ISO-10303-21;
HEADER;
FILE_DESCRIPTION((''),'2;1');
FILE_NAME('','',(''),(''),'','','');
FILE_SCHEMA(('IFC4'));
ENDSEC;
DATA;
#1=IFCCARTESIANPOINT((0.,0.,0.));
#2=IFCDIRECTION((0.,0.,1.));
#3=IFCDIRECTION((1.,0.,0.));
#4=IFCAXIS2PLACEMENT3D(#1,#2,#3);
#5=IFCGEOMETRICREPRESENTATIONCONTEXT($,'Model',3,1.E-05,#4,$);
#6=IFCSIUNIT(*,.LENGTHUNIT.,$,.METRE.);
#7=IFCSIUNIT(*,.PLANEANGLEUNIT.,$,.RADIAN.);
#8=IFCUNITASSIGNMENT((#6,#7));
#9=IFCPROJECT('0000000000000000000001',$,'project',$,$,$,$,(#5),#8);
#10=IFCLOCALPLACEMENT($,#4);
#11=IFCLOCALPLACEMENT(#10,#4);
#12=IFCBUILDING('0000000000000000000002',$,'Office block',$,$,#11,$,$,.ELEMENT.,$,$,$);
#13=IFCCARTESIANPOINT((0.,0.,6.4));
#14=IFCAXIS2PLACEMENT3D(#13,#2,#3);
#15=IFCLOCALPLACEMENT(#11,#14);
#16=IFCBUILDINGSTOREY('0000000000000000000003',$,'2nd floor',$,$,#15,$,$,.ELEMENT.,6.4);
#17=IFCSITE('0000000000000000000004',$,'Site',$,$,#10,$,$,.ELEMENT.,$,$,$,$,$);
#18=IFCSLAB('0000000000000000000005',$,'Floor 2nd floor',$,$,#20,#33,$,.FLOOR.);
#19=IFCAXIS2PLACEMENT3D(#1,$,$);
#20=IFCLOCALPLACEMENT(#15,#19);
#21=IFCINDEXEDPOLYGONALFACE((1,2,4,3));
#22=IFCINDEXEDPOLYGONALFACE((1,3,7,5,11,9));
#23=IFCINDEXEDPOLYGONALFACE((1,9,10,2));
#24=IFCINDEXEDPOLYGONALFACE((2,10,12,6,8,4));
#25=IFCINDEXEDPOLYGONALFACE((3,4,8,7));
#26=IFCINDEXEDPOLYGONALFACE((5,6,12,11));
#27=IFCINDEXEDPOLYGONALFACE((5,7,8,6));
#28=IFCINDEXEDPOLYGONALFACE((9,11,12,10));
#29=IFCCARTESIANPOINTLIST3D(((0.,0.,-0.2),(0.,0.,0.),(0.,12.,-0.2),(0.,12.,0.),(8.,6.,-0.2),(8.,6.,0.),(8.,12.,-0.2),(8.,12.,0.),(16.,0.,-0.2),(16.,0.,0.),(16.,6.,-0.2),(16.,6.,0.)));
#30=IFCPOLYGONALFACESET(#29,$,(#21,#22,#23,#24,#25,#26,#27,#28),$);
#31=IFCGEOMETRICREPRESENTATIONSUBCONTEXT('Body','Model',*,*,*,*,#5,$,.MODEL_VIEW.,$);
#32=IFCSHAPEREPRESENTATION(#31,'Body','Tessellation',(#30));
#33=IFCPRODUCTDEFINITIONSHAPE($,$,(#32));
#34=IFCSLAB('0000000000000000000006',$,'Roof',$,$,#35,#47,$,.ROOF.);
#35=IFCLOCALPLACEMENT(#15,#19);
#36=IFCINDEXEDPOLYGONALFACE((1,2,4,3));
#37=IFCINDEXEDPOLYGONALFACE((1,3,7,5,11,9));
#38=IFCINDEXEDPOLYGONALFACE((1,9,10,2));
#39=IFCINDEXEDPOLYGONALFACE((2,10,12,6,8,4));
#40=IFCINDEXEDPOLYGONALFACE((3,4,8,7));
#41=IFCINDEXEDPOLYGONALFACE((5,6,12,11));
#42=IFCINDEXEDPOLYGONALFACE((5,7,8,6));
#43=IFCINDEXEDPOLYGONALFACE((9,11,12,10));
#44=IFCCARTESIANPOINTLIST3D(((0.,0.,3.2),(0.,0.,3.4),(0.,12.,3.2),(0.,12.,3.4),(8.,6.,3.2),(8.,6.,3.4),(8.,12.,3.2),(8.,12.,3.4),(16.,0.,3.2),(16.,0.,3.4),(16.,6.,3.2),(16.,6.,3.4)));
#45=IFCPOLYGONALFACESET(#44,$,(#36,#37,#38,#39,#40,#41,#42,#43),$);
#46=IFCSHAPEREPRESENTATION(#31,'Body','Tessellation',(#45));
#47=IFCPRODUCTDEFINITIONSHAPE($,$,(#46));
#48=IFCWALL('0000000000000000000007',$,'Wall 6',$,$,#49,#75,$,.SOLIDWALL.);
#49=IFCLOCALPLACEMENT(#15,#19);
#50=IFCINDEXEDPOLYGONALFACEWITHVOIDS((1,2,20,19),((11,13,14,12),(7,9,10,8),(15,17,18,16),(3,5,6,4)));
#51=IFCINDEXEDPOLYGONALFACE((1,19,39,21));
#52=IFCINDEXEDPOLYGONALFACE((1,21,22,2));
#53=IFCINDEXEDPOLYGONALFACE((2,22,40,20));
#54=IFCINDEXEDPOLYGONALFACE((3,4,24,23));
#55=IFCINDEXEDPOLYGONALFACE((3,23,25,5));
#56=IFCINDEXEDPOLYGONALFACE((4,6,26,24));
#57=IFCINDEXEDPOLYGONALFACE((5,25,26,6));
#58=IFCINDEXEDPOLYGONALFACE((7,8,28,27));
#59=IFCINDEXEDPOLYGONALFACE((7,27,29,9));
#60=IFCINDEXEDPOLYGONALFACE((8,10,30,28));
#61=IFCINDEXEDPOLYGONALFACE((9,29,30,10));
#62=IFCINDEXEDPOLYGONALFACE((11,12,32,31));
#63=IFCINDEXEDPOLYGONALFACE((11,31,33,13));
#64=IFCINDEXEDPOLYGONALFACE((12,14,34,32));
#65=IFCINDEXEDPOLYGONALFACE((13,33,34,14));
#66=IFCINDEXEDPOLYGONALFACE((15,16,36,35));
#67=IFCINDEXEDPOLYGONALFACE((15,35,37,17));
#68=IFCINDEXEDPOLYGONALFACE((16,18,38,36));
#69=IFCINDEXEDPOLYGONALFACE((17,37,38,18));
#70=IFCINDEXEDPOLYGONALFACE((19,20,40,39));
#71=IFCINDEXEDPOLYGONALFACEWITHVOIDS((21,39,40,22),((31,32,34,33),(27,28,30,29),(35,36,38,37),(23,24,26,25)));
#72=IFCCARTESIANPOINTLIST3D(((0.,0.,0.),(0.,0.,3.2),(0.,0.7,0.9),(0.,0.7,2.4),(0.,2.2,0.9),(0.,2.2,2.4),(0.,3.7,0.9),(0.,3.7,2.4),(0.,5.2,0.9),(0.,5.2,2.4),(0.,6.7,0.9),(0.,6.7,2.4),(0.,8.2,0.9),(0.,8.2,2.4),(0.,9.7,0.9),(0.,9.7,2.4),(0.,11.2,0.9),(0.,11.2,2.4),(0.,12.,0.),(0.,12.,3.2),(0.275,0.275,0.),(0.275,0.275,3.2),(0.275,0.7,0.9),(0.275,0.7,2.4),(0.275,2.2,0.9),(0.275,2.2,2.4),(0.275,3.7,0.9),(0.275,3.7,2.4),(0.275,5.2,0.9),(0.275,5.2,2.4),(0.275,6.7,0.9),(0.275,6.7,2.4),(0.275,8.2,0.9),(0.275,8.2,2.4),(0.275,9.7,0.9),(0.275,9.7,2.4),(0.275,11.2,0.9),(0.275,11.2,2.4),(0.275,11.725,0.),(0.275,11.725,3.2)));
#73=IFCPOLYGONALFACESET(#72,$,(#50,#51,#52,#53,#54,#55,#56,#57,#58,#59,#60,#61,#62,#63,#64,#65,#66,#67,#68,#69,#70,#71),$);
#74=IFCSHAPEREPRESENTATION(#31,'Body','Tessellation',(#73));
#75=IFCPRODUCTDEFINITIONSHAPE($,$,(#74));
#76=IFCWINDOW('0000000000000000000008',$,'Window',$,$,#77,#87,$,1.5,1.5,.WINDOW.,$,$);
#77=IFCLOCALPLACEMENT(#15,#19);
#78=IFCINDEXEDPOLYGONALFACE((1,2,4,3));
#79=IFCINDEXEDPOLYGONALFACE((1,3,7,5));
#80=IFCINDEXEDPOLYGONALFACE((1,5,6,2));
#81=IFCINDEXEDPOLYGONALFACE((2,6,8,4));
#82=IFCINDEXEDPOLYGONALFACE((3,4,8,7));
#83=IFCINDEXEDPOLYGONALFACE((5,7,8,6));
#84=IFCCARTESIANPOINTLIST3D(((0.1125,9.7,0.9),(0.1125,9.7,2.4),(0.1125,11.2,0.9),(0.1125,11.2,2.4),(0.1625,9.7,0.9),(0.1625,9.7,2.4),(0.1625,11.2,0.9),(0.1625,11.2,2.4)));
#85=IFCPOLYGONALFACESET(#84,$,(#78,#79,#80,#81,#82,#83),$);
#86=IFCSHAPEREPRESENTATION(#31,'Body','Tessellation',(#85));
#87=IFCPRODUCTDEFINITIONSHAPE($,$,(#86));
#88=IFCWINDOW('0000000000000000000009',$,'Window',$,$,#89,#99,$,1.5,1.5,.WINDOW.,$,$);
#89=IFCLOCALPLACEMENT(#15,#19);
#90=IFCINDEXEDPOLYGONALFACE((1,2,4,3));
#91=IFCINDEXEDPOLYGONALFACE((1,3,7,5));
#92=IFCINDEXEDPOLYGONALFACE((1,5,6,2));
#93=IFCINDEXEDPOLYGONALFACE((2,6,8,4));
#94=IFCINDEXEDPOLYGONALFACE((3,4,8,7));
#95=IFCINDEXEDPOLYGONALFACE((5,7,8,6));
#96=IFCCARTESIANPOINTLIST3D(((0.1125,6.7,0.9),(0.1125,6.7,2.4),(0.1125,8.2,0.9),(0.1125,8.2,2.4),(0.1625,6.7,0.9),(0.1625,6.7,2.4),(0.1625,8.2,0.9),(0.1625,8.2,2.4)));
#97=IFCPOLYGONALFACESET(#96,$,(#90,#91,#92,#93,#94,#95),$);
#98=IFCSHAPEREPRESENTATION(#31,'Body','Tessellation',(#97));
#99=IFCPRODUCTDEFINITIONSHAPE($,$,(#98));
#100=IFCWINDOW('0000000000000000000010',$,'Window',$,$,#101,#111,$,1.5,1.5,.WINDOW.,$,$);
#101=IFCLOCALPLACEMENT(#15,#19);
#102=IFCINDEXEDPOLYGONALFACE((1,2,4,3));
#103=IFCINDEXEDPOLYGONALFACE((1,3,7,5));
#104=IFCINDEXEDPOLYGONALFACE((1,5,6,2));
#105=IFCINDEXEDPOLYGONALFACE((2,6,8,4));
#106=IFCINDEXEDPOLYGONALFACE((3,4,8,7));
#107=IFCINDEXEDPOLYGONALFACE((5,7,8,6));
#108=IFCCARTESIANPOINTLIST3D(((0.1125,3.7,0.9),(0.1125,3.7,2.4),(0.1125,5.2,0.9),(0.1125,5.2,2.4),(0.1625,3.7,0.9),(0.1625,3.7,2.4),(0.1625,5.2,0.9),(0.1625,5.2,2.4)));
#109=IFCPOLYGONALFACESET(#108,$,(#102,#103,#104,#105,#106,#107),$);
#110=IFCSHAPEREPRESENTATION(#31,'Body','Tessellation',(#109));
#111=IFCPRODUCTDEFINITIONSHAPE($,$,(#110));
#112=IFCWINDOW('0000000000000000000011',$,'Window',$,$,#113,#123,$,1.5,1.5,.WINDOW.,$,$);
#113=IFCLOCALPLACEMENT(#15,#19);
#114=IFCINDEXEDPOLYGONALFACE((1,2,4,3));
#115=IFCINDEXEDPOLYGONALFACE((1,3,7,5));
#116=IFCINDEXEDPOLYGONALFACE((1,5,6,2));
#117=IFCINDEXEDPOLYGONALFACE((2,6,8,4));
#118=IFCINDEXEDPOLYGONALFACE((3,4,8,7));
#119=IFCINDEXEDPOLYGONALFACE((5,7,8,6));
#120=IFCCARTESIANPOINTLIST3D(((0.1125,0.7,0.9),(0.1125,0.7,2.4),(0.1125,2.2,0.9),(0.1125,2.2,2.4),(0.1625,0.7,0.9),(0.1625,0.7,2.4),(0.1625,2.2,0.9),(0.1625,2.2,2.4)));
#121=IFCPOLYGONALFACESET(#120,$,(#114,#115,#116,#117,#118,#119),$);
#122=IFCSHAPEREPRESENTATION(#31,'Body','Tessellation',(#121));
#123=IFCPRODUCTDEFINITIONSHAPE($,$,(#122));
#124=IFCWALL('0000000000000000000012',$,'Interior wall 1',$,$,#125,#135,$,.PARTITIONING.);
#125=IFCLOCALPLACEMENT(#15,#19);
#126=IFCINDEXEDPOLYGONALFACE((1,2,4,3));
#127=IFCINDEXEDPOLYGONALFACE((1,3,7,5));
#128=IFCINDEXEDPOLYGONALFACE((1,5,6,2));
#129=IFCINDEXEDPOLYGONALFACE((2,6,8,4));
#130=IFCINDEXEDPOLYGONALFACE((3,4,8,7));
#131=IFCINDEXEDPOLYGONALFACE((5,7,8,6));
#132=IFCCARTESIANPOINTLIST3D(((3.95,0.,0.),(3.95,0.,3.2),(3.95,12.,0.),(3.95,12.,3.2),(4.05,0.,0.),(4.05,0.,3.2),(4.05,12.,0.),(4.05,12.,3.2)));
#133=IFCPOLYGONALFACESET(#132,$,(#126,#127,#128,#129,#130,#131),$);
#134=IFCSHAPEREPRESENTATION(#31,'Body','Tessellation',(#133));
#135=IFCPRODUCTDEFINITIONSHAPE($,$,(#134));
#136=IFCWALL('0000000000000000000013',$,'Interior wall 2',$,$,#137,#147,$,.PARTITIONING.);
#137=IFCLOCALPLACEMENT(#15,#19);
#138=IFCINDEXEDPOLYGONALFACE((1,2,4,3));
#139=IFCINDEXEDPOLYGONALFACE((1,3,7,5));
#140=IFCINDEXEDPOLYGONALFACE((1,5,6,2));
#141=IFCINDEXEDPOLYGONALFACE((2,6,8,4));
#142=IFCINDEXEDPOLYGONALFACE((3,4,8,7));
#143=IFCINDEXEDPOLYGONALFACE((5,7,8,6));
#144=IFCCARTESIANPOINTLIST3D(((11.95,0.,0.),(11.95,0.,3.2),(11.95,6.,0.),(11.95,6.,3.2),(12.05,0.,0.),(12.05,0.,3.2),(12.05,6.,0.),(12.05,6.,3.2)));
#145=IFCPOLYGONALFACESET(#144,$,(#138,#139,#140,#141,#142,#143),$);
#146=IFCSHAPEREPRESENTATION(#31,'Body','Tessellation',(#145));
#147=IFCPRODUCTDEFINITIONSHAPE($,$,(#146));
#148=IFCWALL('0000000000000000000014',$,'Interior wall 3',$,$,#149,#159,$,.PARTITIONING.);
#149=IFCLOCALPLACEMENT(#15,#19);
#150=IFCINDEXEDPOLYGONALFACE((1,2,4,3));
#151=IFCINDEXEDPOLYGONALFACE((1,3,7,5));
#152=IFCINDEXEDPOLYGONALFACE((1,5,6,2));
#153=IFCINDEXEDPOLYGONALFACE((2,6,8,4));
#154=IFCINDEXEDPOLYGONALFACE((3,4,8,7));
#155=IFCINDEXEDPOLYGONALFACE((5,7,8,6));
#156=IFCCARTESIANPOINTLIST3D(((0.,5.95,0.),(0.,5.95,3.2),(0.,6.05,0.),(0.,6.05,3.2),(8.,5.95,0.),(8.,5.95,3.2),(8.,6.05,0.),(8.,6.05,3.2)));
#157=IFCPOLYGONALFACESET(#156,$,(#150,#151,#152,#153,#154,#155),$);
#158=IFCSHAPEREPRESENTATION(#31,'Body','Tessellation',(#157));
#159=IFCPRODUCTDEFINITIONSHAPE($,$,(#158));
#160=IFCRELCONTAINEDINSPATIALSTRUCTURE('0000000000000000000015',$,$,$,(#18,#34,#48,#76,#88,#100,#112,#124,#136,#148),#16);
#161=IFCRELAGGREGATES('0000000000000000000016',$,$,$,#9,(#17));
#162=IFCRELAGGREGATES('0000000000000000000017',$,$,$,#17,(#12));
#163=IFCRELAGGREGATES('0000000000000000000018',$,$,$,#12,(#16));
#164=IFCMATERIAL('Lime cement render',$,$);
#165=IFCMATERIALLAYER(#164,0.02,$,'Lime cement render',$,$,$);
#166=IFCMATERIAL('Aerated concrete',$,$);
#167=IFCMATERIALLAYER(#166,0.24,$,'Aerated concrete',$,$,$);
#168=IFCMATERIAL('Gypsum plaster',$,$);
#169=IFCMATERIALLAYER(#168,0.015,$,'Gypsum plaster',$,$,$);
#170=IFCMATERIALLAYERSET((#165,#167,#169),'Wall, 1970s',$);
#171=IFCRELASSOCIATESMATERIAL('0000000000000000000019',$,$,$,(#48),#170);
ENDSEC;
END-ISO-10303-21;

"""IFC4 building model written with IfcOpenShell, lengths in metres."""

from ifc_helpers import new_model, si_unit, frame, origin_with_axes, place, context, subcontext, project, spatial, polyline, outline, extrude, material, layer, layer_set, layer_usage, element, fill, save


model = new_model("IFC4")

# Units and contexts
model_context = context("Model", 3, precision=1e-05, world=origin_with_axes())
body_context = subcontext(model_context, "Body", "Model", "MODEL_VIEW")
ifc_project = project(units=[si_unit("LENGTHUNIT", "METRE"), si_unit("PLANEANGLEUNIT", "RADIAN")], contexts=[model_context])

# Site, building, storey
site_placement = place(None, origin_with_axes())
site = spatial("IfcSite", under=ifc_project, at=site_placement, Name="Site", CompositionType="ELEMENT")
building_placement = place(site_placement, origin_with_axes())
building = spatial("IfcBuilding", under=site, at=building_placement, Name="Office block", CompositionType="ELEMENT")
storey_placement = place(building_placement, frame((0.0, 0.0, 6.4), z_axis=(0.0, 0.0, 1.0), x_axis=(1.0, 0.0, 0.0)))
storey = spatial("IfcBuildingStorey", under=building, at=storey_placement, Name="2nd floor", CompositionType="ELEMENT", Elevation=6.4)

# Slabs
slab_1_placement = place(storey_placement, origin_with_axes())
element("IfcSlab", 1, at=slab_1_placement, inside=storey, Name="Floor 2nd floor", PredefinedType="FLOOR", context=body_context, shape_type="SweptSolid", body=[
    extrude(outline(polyline([(0.0, 0.0), (16.0, 0.0), (16.0, 6.0), (8.0, 6.0), (8.0, 12.0), (0.0, 12.0), (0.0, 0.0)])), frame((0.0, 0.0, -0.2), z_axis=(0.0, 0.0, 1.0), x_axis=(1.0, 0.0, 0.0)), (0.0, 0.0, 1.0), 0.2),
])
slab_2_placement = place(storey_placement, origin_with_axes())
element("IfcSlab", 2, at=slab_2_placement, inside=storey, Name="Roof", PredefinedType="ROOF", context=body_context, shape_type="SweptSolid", body=[
    extrude(outline(polyline([(0.0, 0.0), (16.0, 0.0), (16.0, 6.0), (8.0, 6.0), (8.0, 12.0), (0.0, 12.0), (0.0, 0.0)])), frame((0.0, 0.0, 3.2), z_axis=(0.0, 0.0, 1.0), x_axis=(1.0, 0.0, 0.0)), (0.0, 0.0, 1.0), 0.2),
])

# Wall, openings, windows
ifc_material_1 = material(Name="Lime cement render")
ifc_layer_1 = layer(ifc_material_1, 0.02, Name="Lime cement render")
ifc_material_2 = material(Name="Aerated concrete")
ifc_layer_2 = layer(ifc_material_2, 0.24, Name="Aerated concrete")
ifc_material_3 = material(Name="Gypsum plaster")
ifc_layer_3 = layer(ifc_material_3, 0.015, Name="Gypsum plaster")
ifc_layer_set = layer_set([ifc_layer_1, ifc_layer_2, ifc_layer_3], Name="Wall, 1970s")
ifc_layer_usage = layer_usage(ifc_layer_set, "AXIS2", "NEGATIVE", 0.0)
wall_1_placement = place(storey_placement, origin_with_axes())
wall_1 = element("IfcWall", 3, at=wall_1_placement, inside=storey, material=ifc_layer_usage, Name="Wall 6", PredefinedType="SOLIDWALL", context=body_context, shape_type="SweptSolid", body=[
    extrude(outline(polyline([(0.0, 12.0), (0.0, 0.0), (0.275, 0.275), (0.275, 11.725), (0.0, 12.0)])), origin_with_axes(), (0.0, 0.0, 1.0), 3.2),
])
opening_1_placement = place(storey_placement, origin_with_axes())
opening_1 = element("IfcOpeningElement", 4, at=opening_1_placement, cuts=wall_1, PredefinedType="OPENING", context=body_context, shape_type="SweptSolid", body=[
    extrude(outline(polyline([(-0.01, 11.2), (-0.01, 9.7), (0.285, 9.7), (0.285, 11.2), (-0.01, 11.2)])), frame((0.0, 0.0, 0.9), z_axis=(0.0, 0.0, 1.0), x_axis=(1.0, 0.0, 0.0)), (0.0, 0.0, 1.0), 1.5),
])
opening_2_placement = place(storey_placement, origin_with_axes())
opening_2 = element("IfcOpeningElement", 5, at=opening_2_placement, cuts=wall_1, PredefinedType="OPENING", context=body_context, shape_type="SweptSolid", body=[
    extrude(outline(polyline([(-0.01, 8.2), (-0.01, 6.7), (0.285, 6.7), (0.285, 8.2), (-0.01, 8.2)])), frame((0.0, 0.0, 0.9), z_axis=(0.0, 0.0, 1.0), x_axis=(1.0, 0.0, 0.0)), (0.0, 0.0, 1.0), 1.5),
])
opening_3_placement = place(storey_placement, origin_with_axes())
opening_3 = element("IfcOpeningElement", 6, at=opening_3_placement, cuts=wall_1, PredefinedType="OPENING", context=body_context, shape_type="SweptSolid", body=[
    extrude(outline(polyline([(-0.01, 5.2), (-0.01, 3.7), (0.285, 3.7), (0.285, 5.2), (-0.01, 5.2)])), frame((0.0, 0.0, 0.9), z_axis=(0.0, 0.0, 1.0), x_axis=(1.0, 0.0, 0.0)), (0.0, 0.0, 1.0), 1.5),
])
opening_4_placement = place(storey_placement, origin_with_axes())
opening_4 = element("IfcOpeningElement", 7, at=opening_4_placement, cuts=wall_1, PredefinedType="OPENING", context=body_context, shape_type="SweptSolid", body=[
    extrude(outline(polyline([(-0.01, 2.2), (-0.01, 0.7), (0.285, 0.7), (0.285, 2.2), (-0.01, 2.2)])), frame((0.0, 0.0, 0.9), z_axis=(0.0, 0.0, 1.0), x_axis=(1.0, 0.0, 0.0)), (0.0, 0.0, 1.0), 1.5),
])
window_1_placement = place(storey_placement, origin_with_axes())
window_1 = element("IfcWindow", 8, at=window_1_placement, inside=storey, Name="Window", OverallHeight=1.5, OverallWidth=1.5, PredefinedType="WINDOW", context=body_context, shape_type="SweptSolid", body=[
    extrude(outline(polyline([(0.1125, 11.2), (0.1125, 9.7), (0.1625, 9.7), (0.1625, 11.2), (0.1125, 11.2)])), frame((0.0, 0.0, 0.9), z_axis=(0.0, 0.0, 1.0), x_axis=(1.0, 0.0, 0.0)), (0.0, 0.0, 1.0), 1.5),
])
fill(opening_1, window_1)
window_2_placement = place(storey_placement, origin_with_axes())
window_2 = element("IfcWindow", 9, at=window_2_placement, inside=storey, Name="Window", OverallHeight=1.5, OverallWidth=1.5, PredefinedType="WINDOW", context=body_context, shape_type="SweptSolid", body=[
    extrude(outline(polyline([(0.1125, 8.2), (0.1125, 6.7), (0.1625, 6.7), (0.1625, 8.2), (0.1125, 8.2)])), frame((0.0, 0.0, 0.9), z_axis=(0.0, 0.0, 1.0), x_axis=(1.0, 0.0, 0.0)), (0.0, 0.0, 1.0), 1.5),
])
fill(opening_2, window_2)
window_3_placement = place(storey_placement, origin_with_axes())
window_3 = element("IfcWindow", 10, at=window_3_placement, inside=storey, Name="Window", OverallHeight=1.5, OverallWidth=1.5, PredefinedType="WINDOW", context=body_context, shape_type="SweptSolid", body=[
    extrude(outline(polyline([(0.1125, 5.2), (0.1125, 3.7), (0.1625, 3.7), (0.1625, 5.2), (0.1125, 5.2)])), frame((0.0, 0.0, 0.9), z_axis=(0.0, 0.0, 1.0), x_axis=(1.0, 0.0, 0.0)), (0.0, 0.0, 1.0), 1.5),
])
fill(opening_3, window_3)
window_4_placement = place(storey_placement, origin_with_axes())
window_4 = element("IfcWindow", 11, at=window_4_placement, inside=storey, Name="Window", OverallHeight=1.5, OverallWidth=1.5, PredefinedType="WINDOW", context=body_context, shape_type="SweptSolid", body=[
    extrude(outline(polyline([(0.1125, 2.2), (0.1125, 0.7), (0.1625, 0.7), (0.1625, 2.2), (0.1125, 2.2)])), frame((0.0, 0.0, 0.9), z_axis=(0.0, 0.0, 1.0), x_axis=(1.0, 0.0, 0.0)), (0.0, 0.0, 1.0), 1.5),
])
fill(opening_4, window_4)

# Walls
wall_2_placement = place(storey_placement, origin_with_axes())
element("IfcWall", 12, at=wall_2_placement, inside=storey, Name="Interior wall 1", PredefinedType="PARTITIONING", context=body_context, shape_type="SweptSolid", body=[
    extrude(outline(polyline([(3.95, 0.0), (3.95, 12.0), (4.05, 12.0), (4.05, 0.0), (3.95, 0.0)])), origin_with_axes(), (0.0, 0.0, 1.0), 3.2),
])
wall_3_placement = place(storey_placement, origin_with_axes())
element("IfcWall", 13, at=wall_3_placement, inside=storey, Name="Interior wall 2", PredefinedType="PARTITIONING", context=body_context, shape_type="SweptSolid", body=[
    extrude(outline(polyline([(11.95, 0.0), (11.95, 6.0), (12.05, 6.0), (12.05, 0.0), (11.95, 0.0)])), origin_with_axes(), (0.0, 0.0, 1.0), 3.2),
])
wall_4_placement = place(storey_placement, origin_with_axes())
element("IfcWall", 14, at=wall_4_placement, inside=storey, Name="Interior wall 3", PredefinedType="PARTITIONING", context=body_context, shape_type="SweptSolid", body=[
    extrude(outline(polyline([(0.0, 6.05), (8.0, 6.05), (8.0, 5.95), (0.0, 5.95), (0.0, 6.05)])), origin_with_axes(), (0.0, 0.0, 1.0), 3.2),
])

save(model, "model.ifc")
